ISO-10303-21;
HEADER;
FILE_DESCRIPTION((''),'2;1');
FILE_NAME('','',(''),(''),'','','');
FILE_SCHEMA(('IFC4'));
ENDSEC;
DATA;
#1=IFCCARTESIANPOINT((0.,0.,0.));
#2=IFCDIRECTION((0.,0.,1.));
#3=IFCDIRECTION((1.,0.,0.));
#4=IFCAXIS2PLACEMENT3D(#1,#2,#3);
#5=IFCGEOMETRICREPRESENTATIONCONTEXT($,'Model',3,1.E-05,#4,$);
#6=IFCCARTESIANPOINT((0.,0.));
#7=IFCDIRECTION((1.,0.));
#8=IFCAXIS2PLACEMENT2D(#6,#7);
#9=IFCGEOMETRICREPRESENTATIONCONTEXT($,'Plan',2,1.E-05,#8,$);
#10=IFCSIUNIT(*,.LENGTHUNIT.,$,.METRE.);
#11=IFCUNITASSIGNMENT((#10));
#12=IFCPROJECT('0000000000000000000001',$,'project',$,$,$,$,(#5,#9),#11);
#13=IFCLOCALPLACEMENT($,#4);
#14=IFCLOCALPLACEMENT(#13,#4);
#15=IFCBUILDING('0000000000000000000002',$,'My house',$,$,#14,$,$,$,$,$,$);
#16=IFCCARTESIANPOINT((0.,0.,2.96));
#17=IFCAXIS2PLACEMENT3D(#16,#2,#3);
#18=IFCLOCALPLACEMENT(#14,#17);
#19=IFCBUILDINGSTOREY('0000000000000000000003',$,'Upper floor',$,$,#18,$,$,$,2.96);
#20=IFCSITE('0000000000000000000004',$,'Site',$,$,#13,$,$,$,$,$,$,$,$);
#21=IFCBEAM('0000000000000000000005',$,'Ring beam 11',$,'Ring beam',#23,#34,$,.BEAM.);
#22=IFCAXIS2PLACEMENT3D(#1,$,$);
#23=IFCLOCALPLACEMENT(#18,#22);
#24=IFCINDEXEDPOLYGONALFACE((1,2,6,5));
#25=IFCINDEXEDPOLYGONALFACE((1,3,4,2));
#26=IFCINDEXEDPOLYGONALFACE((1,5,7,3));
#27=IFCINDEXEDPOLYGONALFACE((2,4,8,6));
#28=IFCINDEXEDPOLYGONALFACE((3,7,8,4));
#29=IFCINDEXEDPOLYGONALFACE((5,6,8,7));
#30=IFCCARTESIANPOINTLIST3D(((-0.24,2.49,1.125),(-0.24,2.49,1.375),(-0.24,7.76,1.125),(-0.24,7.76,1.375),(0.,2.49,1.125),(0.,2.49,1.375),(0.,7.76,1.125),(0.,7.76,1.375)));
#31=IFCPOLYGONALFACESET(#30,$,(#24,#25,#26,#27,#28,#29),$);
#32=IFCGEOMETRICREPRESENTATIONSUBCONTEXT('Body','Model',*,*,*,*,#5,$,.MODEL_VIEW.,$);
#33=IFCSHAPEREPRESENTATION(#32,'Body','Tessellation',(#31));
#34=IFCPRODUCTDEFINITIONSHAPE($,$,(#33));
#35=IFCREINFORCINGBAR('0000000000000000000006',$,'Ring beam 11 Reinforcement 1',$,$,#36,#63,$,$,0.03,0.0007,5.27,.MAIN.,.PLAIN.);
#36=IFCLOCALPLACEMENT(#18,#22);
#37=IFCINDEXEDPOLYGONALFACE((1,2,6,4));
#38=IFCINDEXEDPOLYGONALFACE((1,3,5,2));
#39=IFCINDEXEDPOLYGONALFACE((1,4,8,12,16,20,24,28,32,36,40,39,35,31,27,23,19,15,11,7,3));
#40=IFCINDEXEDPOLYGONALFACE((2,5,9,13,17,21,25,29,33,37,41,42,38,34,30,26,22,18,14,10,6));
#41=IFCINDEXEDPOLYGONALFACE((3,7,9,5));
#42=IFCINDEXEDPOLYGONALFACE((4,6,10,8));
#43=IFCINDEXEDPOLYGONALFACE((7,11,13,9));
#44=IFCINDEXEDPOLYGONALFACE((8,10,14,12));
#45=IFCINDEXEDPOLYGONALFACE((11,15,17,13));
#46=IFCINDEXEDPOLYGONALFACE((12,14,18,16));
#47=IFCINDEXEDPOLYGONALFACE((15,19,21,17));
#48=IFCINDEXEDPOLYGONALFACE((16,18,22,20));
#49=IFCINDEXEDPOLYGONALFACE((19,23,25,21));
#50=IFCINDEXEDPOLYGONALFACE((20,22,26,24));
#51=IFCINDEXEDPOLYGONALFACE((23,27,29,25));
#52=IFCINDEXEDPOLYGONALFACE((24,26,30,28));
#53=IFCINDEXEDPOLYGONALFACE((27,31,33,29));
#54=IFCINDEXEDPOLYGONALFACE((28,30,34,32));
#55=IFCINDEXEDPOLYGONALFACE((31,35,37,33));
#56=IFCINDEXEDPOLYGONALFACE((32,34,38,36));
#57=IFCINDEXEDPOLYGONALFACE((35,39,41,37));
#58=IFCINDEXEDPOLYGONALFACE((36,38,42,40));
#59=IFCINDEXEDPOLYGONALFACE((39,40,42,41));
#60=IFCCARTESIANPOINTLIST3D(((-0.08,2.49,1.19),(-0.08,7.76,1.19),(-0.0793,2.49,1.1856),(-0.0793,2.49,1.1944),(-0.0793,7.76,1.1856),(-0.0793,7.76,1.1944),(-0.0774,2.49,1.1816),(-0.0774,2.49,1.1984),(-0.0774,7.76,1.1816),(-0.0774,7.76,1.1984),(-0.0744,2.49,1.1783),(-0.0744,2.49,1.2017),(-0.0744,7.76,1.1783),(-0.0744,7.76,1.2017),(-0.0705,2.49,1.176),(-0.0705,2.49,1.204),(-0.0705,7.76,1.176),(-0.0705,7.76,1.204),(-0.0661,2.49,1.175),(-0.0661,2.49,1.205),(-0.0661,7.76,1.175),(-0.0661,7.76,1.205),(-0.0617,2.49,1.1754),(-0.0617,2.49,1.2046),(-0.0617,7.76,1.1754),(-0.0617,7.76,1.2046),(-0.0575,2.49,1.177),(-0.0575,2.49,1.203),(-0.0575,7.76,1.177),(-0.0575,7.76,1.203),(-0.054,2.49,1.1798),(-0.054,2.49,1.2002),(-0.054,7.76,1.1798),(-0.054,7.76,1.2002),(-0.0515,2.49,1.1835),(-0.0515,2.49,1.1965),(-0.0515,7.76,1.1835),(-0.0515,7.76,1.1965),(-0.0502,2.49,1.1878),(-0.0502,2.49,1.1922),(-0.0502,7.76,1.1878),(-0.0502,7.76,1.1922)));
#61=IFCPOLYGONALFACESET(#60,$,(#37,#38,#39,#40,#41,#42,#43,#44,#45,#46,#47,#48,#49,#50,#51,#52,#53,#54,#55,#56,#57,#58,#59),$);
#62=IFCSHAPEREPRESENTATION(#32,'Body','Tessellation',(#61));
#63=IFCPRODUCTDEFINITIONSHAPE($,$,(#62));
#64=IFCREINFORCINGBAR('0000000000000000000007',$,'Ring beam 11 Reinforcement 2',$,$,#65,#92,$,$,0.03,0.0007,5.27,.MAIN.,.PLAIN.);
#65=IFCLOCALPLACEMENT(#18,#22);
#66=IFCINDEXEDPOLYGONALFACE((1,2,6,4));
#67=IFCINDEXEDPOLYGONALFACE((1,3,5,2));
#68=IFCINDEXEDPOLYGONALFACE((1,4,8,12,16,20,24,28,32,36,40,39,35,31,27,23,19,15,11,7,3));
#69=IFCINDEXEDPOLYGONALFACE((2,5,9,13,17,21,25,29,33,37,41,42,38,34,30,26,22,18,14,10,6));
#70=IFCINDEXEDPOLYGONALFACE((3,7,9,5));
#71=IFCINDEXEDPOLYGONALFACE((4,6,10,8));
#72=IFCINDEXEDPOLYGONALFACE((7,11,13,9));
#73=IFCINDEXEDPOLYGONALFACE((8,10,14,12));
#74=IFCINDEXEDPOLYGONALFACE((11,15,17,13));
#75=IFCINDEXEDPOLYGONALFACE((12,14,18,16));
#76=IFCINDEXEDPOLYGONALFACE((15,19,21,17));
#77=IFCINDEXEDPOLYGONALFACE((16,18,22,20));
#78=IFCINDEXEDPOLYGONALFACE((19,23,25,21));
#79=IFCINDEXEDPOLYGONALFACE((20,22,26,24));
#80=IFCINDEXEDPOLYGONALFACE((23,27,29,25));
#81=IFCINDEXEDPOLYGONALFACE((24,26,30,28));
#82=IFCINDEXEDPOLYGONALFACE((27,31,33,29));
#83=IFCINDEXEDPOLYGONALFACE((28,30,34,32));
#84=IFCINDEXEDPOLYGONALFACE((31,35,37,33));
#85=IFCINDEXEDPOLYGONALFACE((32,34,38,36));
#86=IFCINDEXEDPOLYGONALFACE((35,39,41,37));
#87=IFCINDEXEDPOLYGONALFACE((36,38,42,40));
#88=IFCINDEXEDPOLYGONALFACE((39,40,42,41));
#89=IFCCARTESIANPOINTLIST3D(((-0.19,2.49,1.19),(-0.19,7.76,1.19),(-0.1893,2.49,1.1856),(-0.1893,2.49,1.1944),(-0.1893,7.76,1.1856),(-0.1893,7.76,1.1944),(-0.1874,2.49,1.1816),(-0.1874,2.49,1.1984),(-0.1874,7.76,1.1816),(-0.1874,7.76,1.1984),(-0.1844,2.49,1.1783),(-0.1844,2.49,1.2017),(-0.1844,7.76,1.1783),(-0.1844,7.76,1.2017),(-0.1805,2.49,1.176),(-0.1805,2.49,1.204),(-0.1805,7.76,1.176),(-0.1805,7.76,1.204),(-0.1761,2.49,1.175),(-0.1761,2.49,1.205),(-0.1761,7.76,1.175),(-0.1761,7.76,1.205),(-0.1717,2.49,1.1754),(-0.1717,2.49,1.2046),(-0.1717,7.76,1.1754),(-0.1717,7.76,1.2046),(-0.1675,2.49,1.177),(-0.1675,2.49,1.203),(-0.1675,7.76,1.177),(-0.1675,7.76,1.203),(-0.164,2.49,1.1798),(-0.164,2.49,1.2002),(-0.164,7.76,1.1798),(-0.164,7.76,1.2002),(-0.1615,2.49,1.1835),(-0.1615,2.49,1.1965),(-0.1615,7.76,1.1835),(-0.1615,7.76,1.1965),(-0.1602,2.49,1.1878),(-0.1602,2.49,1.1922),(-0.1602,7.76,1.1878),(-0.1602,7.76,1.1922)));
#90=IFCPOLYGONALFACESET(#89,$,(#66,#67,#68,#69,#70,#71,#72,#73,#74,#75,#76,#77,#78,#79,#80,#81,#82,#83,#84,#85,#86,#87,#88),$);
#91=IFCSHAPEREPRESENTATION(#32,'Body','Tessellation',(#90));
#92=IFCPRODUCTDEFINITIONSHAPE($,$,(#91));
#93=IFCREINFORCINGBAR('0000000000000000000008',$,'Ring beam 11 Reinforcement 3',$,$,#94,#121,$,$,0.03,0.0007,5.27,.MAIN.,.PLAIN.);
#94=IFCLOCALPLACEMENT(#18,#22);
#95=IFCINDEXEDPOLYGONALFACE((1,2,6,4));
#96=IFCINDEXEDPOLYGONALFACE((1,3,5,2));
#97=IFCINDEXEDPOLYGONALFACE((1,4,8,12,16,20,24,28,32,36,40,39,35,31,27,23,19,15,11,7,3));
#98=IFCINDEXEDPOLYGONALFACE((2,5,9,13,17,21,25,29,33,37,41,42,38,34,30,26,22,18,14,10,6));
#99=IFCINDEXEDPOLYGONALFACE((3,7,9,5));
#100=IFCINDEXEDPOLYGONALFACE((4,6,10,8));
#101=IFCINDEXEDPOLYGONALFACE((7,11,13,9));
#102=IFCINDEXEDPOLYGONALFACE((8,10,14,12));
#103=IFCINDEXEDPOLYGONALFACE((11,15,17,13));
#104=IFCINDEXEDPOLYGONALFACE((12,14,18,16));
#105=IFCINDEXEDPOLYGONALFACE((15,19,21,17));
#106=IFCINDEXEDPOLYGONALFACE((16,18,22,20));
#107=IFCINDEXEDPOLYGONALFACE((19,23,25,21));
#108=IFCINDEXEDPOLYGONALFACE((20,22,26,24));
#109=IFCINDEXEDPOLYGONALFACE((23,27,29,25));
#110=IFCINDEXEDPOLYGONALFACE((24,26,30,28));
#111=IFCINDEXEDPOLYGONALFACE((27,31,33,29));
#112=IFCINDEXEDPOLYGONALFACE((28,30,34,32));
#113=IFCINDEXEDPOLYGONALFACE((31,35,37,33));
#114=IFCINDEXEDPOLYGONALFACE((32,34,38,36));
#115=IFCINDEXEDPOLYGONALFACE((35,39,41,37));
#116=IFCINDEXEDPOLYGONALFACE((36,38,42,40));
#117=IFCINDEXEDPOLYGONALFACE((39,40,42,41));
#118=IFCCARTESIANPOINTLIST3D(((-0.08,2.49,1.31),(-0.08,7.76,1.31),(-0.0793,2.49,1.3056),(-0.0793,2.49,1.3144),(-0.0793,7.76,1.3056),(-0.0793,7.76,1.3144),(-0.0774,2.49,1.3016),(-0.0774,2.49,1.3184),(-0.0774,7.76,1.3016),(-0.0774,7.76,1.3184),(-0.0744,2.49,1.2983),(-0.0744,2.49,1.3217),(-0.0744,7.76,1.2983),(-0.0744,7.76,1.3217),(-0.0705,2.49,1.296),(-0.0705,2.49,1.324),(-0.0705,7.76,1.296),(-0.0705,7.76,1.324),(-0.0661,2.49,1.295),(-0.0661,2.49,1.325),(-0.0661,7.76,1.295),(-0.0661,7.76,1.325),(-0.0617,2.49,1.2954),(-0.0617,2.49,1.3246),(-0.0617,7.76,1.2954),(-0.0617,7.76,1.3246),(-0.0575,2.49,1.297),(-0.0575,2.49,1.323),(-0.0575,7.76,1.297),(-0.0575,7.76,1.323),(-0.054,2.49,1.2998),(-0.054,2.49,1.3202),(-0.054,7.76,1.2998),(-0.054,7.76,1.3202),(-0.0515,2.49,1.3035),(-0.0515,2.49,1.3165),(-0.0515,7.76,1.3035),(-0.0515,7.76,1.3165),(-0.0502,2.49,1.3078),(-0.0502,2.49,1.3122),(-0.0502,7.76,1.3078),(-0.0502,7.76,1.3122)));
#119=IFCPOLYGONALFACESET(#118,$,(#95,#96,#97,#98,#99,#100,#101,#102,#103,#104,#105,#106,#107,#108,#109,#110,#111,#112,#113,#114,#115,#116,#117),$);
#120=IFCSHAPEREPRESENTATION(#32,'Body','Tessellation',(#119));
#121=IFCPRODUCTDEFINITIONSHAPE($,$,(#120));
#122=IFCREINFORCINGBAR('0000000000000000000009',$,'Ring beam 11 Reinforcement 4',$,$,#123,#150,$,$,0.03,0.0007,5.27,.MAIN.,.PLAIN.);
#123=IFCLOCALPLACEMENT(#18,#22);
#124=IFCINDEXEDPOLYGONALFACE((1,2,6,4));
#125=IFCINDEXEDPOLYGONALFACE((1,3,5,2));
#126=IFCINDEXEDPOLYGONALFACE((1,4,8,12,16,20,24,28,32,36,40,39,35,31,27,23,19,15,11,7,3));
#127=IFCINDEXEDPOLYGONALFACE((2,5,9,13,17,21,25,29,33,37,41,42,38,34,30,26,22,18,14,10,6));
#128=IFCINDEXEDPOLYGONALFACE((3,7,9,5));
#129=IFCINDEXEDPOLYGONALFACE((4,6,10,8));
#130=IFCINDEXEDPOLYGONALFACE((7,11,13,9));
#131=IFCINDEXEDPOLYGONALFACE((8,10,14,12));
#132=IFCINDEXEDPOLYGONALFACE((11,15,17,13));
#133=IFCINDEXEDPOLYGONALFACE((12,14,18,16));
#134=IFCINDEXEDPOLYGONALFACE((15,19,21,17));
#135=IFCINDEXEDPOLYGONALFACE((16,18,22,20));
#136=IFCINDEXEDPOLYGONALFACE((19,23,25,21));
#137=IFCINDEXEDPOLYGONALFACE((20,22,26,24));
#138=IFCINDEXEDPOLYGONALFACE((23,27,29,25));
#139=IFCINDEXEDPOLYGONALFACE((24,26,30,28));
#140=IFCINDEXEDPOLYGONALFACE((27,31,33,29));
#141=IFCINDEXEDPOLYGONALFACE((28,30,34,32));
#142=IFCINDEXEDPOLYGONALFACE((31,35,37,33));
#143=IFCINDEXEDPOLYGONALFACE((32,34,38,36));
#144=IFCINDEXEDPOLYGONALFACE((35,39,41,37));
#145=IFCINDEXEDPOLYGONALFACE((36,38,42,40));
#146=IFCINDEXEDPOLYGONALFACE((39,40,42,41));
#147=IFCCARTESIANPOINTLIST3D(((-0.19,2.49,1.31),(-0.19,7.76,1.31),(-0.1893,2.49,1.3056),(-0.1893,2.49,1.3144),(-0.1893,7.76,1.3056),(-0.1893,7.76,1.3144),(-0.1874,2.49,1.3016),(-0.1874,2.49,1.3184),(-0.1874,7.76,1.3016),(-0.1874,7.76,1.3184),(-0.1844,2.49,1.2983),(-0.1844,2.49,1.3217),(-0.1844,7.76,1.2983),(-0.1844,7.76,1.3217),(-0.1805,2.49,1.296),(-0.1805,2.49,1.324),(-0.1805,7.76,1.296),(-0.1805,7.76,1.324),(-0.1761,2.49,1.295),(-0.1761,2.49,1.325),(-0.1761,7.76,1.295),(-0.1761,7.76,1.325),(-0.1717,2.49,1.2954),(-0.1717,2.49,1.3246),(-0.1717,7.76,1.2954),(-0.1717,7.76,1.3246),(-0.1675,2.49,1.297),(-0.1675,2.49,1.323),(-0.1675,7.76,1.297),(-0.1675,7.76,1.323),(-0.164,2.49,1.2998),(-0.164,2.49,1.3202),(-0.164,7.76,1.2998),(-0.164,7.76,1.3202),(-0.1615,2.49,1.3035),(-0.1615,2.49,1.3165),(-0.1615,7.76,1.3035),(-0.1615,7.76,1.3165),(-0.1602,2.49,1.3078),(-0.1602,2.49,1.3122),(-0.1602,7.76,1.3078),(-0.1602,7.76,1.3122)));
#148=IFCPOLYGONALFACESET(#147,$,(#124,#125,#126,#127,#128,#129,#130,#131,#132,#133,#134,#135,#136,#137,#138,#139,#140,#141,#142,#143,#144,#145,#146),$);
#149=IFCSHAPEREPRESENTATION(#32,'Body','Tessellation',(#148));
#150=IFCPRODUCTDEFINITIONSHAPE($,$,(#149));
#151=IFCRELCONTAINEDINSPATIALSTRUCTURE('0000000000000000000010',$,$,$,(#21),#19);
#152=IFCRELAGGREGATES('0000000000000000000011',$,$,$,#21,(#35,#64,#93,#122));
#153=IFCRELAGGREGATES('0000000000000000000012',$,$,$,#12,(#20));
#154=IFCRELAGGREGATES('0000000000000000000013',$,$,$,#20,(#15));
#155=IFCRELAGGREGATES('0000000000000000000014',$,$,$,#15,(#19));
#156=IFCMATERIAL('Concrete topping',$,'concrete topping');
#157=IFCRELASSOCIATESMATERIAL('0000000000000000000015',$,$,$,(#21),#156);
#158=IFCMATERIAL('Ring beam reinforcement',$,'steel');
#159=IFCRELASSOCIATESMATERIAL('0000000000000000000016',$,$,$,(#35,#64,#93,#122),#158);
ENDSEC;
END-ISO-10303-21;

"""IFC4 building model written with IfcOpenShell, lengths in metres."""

from ifc_helpers import new_model, si_unit, frame, origin_with_axes, origin_2d, origin_2d_with_axis, place, context, subcontext, project, spatial, circle_curve, rectangle, outline, extrude, source, transform, mapped, material, element, aggregate, save


model = new_model("IFC4")

# Units and contexts
model_context = context("Model", 3, precision=1e-05, world=origin_with_axes())
plan_context = context("Plan", 2, precision=1e-05, world=origin_2d_with_axis())
body_context_1 = subcontext(model_context, "Body", "Model", "MODEL_VIEW")
ifc_project = project(units=[si_unit("LENGTHUNIT", "METRE")], contexts=[model_context, plan_context])

# Site, building, storey
site_placement = place(None, origin_with_axes())
site = spatial("IfcSite", under=ifc_project, at=site_placement, Name="Site")
building_placement = place(site_placement, origin_with_axes())
building = spatial("IfcBuilding", under=site, at=building_placement, Name="My house")
storey_placement = place(building_placement, frame((0.0, 0.0, 2.96), z_axis=(0.0, 0.0, 1.0), x_axis=(1.0, 0.0, 0.0)))
storey = spatial("IfcBuildingStorey", under=building, at=storey_placement, Name="Upper floor", Elevation=2.96)

# Shared definitions
ifc_material_1 = material(Name="Concrete topping", Category="concrete topping")

# Beam
shared_shape_1 = source(origin_with_axes(), body_context_1, "Body", "SweptSolid", [
    extrude(rectangle(XDim=0.24, YDim=0.25), frame((0.0, 0.0, 0.0), z_axis=(1.0, 0.0, 0.0), x_axis=(0.0, 1.0, 0.0)), (0.0, 0.0, 1.0), 5.27),
])
beam_1_placement = place(storey_placement, frame((-0.12, 7.76, 1.25), z_axis=(0.0, 0.0, 1.0), x_axis=(0.0, 1.0, 0.0)))
beam_1 = element("IfcBeam", 1, at=beam_1_placement, inside=storey, material=ifc_material_1, Name="Ring beam 11", ObjectType="Ring beam", PredefinedType="BEAM", context=body_context_1, shape_type="MappedRepresentation", body=[
    mapped(shared_shape_1, transform((0.0, 0.0, 0.0), x_axis=(-1.0, 0.0, 0.0), y_axis=(0.0, 1.0, 0.0), z_axis=(0.0, 0.0, 1.0), scale=1.0)),
])

# Reinforcing bars
ifc_material_2 = material(Name="Ring beam reinforcement", Category="steel")
shared_shape_2 = source(origin_with_axes(), body_context_1, "Body", "SweptSolid", [
    extrude(outline(circle_curve(origin_2d(), 0.015)), frame((0.0, 0.0, 0.0), z_axis=(1.0, 0.0, 0.0), x_axis=(0.0, 1.0, 0.0)), (0.0, 0.0, 1.0), 5.27),
])
reinforcing_bar_1_placement = place(beam_1_placement, frame((0.0, -0.055, -0.06), z_axis=(0.0, 0.0, 1.0), x_axis=(1.0, 0.0, 0.0)))
reinforcing_bar_1 = element("IfcReinforcingBar", 2, at=reinforcing_bar_1_placement, material=ifc_material_2, Name="Ring beam 11 Reinforcement 1", BarLength=5.27, BarSurface="PLAIN", CrossSectionArea=0.0007, NominalDiameter=0.03, PredefinedType="MAIN", context=body_context_1, shape_type="MappedRepresentation", body=[
    mapped(shared_shape_2, transform((0.0, 0.0, 0.0), x_axis=(-1.0, 0.0, 0.0), y_axis=(0.0, 1.0, 0.0), z_axis=(0.0, 0.0, 1.0), scale=1.0)),
])
shared_shape_3 = source(origin_with_axes(), body_context_1, "Body", "SweptSolid", [
    extrude(outline(circle_curve(origin_2d(), 0.015)), frame((0.0, 0.0, 0.0), z_axis=(1.0, 0.0, 0.0), x_axis=(0.0, 1.0, 0.0)), (0.0, 0.0, 1.0), 5.27),
])
reinforcing_bar_2_placement = place(beam_1_placement, frame((0.0, 0.055, -0.06), z_axis=(0.0, 0.0, 1.0), x_axis=(1.0, 0.0, 0.0)))
reinforcing_bar_2 = element("IfcReinforcingBar", 3, at=reinforcing_bar_2_placement, material=ifc_material_2, Name="Ring beam 11 Reinforcement 2", BarLength=5.27, BarSurface="PLAIN", CrossSectionArea=0.0007, NominalDiameter=0.03, PredefinedType="MAIN", context=body_context_1, shape_type="MappedRepresentation", body=[
    mapped(shared_shape_3, transform((0.0, 0.0, 0.0), x_axis=(-1.0, 0.0, 0.0), y_axis=(0.0, 1.0, 0.0), z_axis=(0.0, 0.0, 1.0), scale=1.0)),
])
shared_shape_4 = source(origin_with_axes(), body_context_1, "Body", "SweptSolid", [
    extrude(outline(circle_curve(origin_2d(), 0.015)), frame((0.0, 0.0, 0.0), z_axis=(1.0, 0.0, 0.0), x_axis=(0.0, 1.0, 0.0)), (0.0, 0.0, 1.0), 5.27),
])
reinforcing_bar_3_placement = place(beam_1_placement, frame((0.0, -0.055, 0.06), z_axis=(0.0, 0.0, 1.0), x_axis=(1.0, 0.0, 0.0)))
reinforcing_bar_3 = element("IfcReinforcingBar", 4, at=reinforcing_bar_3_placement, material=ifc_material_2, Name="Ring beam 11 Reinforcement 3", BarLength=5.27, BarSurface="PLAIN", CrossSectionArea=0.0007, NominalDiameter=0.03, PredefinedType="MAIN", context=body_context_1, shape_type="MappedRepresentation", body=[
    mapped(shared_shape_4, transform((0.0, 0.0, 0.0), x_axis=(-1.0, 0.0, 0.0), y_axis=(0.0, 1.0, 0.0), z_axis=(0.0, 0.0, 1.0), scale=1.0)),
])
shared_shape_5 = source(origin_with_axes(), body_context_1, "Body", "SweptSolid", [
    extrude(outline(circle_curve(origin_2d(), 0.015)), frame((0.0, 0.0, 0.0), z_axis=(1.0, 0.0, 0.0), x_axis=(0.0, 1.0, 0.0)), (0.0, 0.0, 1.0), 5.27),
])
reinforcing_bar_4_placement = place(beam_1_placement, frame((0.0, 0.055, 0.06), z_axis=(0.0, 0.0, 1.0), x_axis=(1.0, 0.0, 0.0)))
reinforcing_bar_4 = element("IfcReinforcingBar", 5, at=reinforcing_bar_4_placement, material=ifc_material_2, Name="Ring beam 11 Reinforcement 4", BarLength=5.27, BarSurface="PLAIN", CrossSectionArea=0.0007, NominalDiameter=0.03, PredefinedType="MAIN", context=body_context_1, shape_type="MappedRepresentation", body=[
    mapped(shared_shape_5, transform((0.0, 0.0, 0.0), x_axis=(-1.0, 0.0, 0.0), y_axis=(0.0, 1.0, 0.0), z_axis=(0.0, 0.0, 1.0), scale=1.0)),
])
aggregate(beam_1, [reinforcing_bar_1, reinforcing_bar_2, reinforcing_bar_3, reinforcing_bar_4])

save(model, "model.ifc")
